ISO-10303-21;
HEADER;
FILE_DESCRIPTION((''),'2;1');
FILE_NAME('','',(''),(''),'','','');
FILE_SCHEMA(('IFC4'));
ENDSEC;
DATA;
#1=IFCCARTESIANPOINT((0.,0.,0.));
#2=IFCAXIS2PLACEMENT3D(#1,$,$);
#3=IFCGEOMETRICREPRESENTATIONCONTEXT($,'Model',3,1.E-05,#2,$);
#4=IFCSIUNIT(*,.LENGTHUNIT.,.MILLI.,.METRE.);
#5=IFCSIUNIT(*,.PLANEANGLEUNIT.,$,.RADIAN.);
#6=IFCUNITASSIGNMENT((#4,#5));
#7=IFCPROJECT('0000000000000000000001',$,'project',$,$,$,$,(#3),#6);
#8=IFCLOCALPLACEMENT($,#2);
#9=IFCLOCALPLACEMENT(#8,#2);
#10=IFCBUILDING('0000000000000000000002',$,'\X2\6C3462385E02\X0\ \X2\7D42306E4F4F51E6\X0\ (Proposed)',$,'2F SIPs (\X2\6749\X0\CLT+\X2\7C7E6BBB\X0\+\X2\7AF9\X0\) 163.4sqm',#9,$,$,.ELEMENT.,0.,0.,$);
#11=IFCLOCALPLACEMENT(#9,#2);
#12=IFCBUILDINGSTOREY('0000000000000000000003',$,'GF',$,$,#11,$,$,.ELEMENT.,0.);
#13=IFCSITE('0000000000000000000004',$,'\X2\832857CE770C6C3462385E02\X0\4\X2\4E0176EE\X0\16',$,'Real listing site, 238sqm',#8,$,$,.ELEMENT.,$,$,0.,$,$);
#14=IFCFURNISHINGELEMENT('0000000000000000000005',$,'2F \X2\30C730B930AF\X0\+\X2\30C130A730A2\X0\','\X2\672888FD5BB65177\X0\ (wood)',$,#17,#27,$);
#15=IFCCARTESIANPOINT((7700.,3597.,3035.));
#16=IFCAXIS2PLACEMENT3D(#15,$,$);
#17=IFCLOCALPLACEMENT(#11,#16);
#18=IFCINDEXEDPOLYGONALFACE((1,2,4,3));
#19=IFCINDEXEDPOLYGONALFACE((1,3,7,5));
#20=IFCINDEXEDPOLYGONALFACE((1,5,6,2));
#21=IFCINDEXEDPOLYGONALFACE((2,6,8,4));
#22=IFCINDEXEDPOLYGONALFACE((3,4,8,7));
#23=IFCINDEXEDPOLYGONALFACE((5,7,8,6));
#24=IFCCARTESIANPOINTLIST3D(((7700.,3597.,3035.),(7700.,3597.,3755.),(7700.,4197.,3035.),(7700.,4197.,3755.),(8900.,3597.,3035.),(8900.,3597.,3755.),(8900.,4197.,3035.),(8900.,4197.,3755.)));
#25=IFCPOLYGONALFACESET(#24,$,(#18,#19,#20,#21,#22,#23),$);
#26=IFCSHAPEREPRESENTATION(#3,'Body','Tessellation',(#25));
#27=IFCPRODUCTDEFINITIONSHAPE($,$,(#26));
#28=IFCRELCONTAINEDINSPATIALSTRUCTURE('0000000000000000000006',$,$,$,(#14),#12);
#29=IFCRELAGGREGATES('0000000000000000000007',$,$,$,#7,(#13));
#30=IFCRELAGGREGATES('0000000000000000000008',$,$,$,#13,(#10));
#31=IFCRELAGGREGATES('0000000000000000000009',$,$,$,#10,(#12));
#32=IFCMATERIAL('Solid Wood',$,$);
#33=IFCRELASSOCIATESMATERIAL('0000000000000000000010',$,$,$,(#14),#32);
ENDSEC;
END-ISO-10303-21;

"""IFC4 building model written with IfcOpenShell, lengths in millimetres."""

from ifc_helpers import new_model, si_unit, frame, frame_2d, origin, place, context, project, spatial, rectangle, extrude, material, element, save


model = new_model("IFC4")

# Units and contexts
model_context = context("Model", 3, precision=1e-05, world=origin())
ifc_project = project(units=[si_unit("LENGTHUNIT", "METRE", prefix="MILLI"), si_unit("PLANEANGLEUNIT", "RADIAN")], contexts=[model_context])

# Site, building, storey
site_placement = place(None, origin())
site = spatial("IfcSite", under=ifc_project, at=site_placement, Name="茨城県水戸市4丁目16", ObjectType="Real listing site, 238sqm", CompositionType="ELEMENT", RefElevation=0.0)
building_placement = place(site_placement, origin())
building = spatial("IfcBuilding", under=site, at=building_placement, Name="水戸市 終の住処 (Proposed)", ObjectType="2F SIPs (杉CLT+籾殻+竹) 163.4sqm", CompositionType="ELEMENT", ElevationOfRefHeight=0.0, ElevationOfTerrain=0.0)
storey_placement = place(building_placement, origin())
storey = spatial("IfcBuildingStorey", under=building, at=storey_placement, Name="GF", CompositionType="ELEMENT", Elevation=0.0)

# Shared definitions
ifc_material_1 = material(Name="Solid Wood")

# Furnishing element
furnishing_1_placement = place(storey_placement, frame((7700.0, 3597.0, 3035.0)))
element("IfcFurnishingElement", 1, at=furnishing_1_placement, inside=storey, material=ifc_material_1, Name="2F デスク+チェア", Description="木製家具 (wood)", context=model_context, shape_type="SweptSolid", body=[
    extrude(rectangle(XDim=1200.0, YDim=600.0, at=frame_2d((600.0, 300.0))), frame((7700.0, 3597.0, 3035.0)), (0.0, 0.0, 1.0), 720.0),
])

save(model, "model.ifc")
